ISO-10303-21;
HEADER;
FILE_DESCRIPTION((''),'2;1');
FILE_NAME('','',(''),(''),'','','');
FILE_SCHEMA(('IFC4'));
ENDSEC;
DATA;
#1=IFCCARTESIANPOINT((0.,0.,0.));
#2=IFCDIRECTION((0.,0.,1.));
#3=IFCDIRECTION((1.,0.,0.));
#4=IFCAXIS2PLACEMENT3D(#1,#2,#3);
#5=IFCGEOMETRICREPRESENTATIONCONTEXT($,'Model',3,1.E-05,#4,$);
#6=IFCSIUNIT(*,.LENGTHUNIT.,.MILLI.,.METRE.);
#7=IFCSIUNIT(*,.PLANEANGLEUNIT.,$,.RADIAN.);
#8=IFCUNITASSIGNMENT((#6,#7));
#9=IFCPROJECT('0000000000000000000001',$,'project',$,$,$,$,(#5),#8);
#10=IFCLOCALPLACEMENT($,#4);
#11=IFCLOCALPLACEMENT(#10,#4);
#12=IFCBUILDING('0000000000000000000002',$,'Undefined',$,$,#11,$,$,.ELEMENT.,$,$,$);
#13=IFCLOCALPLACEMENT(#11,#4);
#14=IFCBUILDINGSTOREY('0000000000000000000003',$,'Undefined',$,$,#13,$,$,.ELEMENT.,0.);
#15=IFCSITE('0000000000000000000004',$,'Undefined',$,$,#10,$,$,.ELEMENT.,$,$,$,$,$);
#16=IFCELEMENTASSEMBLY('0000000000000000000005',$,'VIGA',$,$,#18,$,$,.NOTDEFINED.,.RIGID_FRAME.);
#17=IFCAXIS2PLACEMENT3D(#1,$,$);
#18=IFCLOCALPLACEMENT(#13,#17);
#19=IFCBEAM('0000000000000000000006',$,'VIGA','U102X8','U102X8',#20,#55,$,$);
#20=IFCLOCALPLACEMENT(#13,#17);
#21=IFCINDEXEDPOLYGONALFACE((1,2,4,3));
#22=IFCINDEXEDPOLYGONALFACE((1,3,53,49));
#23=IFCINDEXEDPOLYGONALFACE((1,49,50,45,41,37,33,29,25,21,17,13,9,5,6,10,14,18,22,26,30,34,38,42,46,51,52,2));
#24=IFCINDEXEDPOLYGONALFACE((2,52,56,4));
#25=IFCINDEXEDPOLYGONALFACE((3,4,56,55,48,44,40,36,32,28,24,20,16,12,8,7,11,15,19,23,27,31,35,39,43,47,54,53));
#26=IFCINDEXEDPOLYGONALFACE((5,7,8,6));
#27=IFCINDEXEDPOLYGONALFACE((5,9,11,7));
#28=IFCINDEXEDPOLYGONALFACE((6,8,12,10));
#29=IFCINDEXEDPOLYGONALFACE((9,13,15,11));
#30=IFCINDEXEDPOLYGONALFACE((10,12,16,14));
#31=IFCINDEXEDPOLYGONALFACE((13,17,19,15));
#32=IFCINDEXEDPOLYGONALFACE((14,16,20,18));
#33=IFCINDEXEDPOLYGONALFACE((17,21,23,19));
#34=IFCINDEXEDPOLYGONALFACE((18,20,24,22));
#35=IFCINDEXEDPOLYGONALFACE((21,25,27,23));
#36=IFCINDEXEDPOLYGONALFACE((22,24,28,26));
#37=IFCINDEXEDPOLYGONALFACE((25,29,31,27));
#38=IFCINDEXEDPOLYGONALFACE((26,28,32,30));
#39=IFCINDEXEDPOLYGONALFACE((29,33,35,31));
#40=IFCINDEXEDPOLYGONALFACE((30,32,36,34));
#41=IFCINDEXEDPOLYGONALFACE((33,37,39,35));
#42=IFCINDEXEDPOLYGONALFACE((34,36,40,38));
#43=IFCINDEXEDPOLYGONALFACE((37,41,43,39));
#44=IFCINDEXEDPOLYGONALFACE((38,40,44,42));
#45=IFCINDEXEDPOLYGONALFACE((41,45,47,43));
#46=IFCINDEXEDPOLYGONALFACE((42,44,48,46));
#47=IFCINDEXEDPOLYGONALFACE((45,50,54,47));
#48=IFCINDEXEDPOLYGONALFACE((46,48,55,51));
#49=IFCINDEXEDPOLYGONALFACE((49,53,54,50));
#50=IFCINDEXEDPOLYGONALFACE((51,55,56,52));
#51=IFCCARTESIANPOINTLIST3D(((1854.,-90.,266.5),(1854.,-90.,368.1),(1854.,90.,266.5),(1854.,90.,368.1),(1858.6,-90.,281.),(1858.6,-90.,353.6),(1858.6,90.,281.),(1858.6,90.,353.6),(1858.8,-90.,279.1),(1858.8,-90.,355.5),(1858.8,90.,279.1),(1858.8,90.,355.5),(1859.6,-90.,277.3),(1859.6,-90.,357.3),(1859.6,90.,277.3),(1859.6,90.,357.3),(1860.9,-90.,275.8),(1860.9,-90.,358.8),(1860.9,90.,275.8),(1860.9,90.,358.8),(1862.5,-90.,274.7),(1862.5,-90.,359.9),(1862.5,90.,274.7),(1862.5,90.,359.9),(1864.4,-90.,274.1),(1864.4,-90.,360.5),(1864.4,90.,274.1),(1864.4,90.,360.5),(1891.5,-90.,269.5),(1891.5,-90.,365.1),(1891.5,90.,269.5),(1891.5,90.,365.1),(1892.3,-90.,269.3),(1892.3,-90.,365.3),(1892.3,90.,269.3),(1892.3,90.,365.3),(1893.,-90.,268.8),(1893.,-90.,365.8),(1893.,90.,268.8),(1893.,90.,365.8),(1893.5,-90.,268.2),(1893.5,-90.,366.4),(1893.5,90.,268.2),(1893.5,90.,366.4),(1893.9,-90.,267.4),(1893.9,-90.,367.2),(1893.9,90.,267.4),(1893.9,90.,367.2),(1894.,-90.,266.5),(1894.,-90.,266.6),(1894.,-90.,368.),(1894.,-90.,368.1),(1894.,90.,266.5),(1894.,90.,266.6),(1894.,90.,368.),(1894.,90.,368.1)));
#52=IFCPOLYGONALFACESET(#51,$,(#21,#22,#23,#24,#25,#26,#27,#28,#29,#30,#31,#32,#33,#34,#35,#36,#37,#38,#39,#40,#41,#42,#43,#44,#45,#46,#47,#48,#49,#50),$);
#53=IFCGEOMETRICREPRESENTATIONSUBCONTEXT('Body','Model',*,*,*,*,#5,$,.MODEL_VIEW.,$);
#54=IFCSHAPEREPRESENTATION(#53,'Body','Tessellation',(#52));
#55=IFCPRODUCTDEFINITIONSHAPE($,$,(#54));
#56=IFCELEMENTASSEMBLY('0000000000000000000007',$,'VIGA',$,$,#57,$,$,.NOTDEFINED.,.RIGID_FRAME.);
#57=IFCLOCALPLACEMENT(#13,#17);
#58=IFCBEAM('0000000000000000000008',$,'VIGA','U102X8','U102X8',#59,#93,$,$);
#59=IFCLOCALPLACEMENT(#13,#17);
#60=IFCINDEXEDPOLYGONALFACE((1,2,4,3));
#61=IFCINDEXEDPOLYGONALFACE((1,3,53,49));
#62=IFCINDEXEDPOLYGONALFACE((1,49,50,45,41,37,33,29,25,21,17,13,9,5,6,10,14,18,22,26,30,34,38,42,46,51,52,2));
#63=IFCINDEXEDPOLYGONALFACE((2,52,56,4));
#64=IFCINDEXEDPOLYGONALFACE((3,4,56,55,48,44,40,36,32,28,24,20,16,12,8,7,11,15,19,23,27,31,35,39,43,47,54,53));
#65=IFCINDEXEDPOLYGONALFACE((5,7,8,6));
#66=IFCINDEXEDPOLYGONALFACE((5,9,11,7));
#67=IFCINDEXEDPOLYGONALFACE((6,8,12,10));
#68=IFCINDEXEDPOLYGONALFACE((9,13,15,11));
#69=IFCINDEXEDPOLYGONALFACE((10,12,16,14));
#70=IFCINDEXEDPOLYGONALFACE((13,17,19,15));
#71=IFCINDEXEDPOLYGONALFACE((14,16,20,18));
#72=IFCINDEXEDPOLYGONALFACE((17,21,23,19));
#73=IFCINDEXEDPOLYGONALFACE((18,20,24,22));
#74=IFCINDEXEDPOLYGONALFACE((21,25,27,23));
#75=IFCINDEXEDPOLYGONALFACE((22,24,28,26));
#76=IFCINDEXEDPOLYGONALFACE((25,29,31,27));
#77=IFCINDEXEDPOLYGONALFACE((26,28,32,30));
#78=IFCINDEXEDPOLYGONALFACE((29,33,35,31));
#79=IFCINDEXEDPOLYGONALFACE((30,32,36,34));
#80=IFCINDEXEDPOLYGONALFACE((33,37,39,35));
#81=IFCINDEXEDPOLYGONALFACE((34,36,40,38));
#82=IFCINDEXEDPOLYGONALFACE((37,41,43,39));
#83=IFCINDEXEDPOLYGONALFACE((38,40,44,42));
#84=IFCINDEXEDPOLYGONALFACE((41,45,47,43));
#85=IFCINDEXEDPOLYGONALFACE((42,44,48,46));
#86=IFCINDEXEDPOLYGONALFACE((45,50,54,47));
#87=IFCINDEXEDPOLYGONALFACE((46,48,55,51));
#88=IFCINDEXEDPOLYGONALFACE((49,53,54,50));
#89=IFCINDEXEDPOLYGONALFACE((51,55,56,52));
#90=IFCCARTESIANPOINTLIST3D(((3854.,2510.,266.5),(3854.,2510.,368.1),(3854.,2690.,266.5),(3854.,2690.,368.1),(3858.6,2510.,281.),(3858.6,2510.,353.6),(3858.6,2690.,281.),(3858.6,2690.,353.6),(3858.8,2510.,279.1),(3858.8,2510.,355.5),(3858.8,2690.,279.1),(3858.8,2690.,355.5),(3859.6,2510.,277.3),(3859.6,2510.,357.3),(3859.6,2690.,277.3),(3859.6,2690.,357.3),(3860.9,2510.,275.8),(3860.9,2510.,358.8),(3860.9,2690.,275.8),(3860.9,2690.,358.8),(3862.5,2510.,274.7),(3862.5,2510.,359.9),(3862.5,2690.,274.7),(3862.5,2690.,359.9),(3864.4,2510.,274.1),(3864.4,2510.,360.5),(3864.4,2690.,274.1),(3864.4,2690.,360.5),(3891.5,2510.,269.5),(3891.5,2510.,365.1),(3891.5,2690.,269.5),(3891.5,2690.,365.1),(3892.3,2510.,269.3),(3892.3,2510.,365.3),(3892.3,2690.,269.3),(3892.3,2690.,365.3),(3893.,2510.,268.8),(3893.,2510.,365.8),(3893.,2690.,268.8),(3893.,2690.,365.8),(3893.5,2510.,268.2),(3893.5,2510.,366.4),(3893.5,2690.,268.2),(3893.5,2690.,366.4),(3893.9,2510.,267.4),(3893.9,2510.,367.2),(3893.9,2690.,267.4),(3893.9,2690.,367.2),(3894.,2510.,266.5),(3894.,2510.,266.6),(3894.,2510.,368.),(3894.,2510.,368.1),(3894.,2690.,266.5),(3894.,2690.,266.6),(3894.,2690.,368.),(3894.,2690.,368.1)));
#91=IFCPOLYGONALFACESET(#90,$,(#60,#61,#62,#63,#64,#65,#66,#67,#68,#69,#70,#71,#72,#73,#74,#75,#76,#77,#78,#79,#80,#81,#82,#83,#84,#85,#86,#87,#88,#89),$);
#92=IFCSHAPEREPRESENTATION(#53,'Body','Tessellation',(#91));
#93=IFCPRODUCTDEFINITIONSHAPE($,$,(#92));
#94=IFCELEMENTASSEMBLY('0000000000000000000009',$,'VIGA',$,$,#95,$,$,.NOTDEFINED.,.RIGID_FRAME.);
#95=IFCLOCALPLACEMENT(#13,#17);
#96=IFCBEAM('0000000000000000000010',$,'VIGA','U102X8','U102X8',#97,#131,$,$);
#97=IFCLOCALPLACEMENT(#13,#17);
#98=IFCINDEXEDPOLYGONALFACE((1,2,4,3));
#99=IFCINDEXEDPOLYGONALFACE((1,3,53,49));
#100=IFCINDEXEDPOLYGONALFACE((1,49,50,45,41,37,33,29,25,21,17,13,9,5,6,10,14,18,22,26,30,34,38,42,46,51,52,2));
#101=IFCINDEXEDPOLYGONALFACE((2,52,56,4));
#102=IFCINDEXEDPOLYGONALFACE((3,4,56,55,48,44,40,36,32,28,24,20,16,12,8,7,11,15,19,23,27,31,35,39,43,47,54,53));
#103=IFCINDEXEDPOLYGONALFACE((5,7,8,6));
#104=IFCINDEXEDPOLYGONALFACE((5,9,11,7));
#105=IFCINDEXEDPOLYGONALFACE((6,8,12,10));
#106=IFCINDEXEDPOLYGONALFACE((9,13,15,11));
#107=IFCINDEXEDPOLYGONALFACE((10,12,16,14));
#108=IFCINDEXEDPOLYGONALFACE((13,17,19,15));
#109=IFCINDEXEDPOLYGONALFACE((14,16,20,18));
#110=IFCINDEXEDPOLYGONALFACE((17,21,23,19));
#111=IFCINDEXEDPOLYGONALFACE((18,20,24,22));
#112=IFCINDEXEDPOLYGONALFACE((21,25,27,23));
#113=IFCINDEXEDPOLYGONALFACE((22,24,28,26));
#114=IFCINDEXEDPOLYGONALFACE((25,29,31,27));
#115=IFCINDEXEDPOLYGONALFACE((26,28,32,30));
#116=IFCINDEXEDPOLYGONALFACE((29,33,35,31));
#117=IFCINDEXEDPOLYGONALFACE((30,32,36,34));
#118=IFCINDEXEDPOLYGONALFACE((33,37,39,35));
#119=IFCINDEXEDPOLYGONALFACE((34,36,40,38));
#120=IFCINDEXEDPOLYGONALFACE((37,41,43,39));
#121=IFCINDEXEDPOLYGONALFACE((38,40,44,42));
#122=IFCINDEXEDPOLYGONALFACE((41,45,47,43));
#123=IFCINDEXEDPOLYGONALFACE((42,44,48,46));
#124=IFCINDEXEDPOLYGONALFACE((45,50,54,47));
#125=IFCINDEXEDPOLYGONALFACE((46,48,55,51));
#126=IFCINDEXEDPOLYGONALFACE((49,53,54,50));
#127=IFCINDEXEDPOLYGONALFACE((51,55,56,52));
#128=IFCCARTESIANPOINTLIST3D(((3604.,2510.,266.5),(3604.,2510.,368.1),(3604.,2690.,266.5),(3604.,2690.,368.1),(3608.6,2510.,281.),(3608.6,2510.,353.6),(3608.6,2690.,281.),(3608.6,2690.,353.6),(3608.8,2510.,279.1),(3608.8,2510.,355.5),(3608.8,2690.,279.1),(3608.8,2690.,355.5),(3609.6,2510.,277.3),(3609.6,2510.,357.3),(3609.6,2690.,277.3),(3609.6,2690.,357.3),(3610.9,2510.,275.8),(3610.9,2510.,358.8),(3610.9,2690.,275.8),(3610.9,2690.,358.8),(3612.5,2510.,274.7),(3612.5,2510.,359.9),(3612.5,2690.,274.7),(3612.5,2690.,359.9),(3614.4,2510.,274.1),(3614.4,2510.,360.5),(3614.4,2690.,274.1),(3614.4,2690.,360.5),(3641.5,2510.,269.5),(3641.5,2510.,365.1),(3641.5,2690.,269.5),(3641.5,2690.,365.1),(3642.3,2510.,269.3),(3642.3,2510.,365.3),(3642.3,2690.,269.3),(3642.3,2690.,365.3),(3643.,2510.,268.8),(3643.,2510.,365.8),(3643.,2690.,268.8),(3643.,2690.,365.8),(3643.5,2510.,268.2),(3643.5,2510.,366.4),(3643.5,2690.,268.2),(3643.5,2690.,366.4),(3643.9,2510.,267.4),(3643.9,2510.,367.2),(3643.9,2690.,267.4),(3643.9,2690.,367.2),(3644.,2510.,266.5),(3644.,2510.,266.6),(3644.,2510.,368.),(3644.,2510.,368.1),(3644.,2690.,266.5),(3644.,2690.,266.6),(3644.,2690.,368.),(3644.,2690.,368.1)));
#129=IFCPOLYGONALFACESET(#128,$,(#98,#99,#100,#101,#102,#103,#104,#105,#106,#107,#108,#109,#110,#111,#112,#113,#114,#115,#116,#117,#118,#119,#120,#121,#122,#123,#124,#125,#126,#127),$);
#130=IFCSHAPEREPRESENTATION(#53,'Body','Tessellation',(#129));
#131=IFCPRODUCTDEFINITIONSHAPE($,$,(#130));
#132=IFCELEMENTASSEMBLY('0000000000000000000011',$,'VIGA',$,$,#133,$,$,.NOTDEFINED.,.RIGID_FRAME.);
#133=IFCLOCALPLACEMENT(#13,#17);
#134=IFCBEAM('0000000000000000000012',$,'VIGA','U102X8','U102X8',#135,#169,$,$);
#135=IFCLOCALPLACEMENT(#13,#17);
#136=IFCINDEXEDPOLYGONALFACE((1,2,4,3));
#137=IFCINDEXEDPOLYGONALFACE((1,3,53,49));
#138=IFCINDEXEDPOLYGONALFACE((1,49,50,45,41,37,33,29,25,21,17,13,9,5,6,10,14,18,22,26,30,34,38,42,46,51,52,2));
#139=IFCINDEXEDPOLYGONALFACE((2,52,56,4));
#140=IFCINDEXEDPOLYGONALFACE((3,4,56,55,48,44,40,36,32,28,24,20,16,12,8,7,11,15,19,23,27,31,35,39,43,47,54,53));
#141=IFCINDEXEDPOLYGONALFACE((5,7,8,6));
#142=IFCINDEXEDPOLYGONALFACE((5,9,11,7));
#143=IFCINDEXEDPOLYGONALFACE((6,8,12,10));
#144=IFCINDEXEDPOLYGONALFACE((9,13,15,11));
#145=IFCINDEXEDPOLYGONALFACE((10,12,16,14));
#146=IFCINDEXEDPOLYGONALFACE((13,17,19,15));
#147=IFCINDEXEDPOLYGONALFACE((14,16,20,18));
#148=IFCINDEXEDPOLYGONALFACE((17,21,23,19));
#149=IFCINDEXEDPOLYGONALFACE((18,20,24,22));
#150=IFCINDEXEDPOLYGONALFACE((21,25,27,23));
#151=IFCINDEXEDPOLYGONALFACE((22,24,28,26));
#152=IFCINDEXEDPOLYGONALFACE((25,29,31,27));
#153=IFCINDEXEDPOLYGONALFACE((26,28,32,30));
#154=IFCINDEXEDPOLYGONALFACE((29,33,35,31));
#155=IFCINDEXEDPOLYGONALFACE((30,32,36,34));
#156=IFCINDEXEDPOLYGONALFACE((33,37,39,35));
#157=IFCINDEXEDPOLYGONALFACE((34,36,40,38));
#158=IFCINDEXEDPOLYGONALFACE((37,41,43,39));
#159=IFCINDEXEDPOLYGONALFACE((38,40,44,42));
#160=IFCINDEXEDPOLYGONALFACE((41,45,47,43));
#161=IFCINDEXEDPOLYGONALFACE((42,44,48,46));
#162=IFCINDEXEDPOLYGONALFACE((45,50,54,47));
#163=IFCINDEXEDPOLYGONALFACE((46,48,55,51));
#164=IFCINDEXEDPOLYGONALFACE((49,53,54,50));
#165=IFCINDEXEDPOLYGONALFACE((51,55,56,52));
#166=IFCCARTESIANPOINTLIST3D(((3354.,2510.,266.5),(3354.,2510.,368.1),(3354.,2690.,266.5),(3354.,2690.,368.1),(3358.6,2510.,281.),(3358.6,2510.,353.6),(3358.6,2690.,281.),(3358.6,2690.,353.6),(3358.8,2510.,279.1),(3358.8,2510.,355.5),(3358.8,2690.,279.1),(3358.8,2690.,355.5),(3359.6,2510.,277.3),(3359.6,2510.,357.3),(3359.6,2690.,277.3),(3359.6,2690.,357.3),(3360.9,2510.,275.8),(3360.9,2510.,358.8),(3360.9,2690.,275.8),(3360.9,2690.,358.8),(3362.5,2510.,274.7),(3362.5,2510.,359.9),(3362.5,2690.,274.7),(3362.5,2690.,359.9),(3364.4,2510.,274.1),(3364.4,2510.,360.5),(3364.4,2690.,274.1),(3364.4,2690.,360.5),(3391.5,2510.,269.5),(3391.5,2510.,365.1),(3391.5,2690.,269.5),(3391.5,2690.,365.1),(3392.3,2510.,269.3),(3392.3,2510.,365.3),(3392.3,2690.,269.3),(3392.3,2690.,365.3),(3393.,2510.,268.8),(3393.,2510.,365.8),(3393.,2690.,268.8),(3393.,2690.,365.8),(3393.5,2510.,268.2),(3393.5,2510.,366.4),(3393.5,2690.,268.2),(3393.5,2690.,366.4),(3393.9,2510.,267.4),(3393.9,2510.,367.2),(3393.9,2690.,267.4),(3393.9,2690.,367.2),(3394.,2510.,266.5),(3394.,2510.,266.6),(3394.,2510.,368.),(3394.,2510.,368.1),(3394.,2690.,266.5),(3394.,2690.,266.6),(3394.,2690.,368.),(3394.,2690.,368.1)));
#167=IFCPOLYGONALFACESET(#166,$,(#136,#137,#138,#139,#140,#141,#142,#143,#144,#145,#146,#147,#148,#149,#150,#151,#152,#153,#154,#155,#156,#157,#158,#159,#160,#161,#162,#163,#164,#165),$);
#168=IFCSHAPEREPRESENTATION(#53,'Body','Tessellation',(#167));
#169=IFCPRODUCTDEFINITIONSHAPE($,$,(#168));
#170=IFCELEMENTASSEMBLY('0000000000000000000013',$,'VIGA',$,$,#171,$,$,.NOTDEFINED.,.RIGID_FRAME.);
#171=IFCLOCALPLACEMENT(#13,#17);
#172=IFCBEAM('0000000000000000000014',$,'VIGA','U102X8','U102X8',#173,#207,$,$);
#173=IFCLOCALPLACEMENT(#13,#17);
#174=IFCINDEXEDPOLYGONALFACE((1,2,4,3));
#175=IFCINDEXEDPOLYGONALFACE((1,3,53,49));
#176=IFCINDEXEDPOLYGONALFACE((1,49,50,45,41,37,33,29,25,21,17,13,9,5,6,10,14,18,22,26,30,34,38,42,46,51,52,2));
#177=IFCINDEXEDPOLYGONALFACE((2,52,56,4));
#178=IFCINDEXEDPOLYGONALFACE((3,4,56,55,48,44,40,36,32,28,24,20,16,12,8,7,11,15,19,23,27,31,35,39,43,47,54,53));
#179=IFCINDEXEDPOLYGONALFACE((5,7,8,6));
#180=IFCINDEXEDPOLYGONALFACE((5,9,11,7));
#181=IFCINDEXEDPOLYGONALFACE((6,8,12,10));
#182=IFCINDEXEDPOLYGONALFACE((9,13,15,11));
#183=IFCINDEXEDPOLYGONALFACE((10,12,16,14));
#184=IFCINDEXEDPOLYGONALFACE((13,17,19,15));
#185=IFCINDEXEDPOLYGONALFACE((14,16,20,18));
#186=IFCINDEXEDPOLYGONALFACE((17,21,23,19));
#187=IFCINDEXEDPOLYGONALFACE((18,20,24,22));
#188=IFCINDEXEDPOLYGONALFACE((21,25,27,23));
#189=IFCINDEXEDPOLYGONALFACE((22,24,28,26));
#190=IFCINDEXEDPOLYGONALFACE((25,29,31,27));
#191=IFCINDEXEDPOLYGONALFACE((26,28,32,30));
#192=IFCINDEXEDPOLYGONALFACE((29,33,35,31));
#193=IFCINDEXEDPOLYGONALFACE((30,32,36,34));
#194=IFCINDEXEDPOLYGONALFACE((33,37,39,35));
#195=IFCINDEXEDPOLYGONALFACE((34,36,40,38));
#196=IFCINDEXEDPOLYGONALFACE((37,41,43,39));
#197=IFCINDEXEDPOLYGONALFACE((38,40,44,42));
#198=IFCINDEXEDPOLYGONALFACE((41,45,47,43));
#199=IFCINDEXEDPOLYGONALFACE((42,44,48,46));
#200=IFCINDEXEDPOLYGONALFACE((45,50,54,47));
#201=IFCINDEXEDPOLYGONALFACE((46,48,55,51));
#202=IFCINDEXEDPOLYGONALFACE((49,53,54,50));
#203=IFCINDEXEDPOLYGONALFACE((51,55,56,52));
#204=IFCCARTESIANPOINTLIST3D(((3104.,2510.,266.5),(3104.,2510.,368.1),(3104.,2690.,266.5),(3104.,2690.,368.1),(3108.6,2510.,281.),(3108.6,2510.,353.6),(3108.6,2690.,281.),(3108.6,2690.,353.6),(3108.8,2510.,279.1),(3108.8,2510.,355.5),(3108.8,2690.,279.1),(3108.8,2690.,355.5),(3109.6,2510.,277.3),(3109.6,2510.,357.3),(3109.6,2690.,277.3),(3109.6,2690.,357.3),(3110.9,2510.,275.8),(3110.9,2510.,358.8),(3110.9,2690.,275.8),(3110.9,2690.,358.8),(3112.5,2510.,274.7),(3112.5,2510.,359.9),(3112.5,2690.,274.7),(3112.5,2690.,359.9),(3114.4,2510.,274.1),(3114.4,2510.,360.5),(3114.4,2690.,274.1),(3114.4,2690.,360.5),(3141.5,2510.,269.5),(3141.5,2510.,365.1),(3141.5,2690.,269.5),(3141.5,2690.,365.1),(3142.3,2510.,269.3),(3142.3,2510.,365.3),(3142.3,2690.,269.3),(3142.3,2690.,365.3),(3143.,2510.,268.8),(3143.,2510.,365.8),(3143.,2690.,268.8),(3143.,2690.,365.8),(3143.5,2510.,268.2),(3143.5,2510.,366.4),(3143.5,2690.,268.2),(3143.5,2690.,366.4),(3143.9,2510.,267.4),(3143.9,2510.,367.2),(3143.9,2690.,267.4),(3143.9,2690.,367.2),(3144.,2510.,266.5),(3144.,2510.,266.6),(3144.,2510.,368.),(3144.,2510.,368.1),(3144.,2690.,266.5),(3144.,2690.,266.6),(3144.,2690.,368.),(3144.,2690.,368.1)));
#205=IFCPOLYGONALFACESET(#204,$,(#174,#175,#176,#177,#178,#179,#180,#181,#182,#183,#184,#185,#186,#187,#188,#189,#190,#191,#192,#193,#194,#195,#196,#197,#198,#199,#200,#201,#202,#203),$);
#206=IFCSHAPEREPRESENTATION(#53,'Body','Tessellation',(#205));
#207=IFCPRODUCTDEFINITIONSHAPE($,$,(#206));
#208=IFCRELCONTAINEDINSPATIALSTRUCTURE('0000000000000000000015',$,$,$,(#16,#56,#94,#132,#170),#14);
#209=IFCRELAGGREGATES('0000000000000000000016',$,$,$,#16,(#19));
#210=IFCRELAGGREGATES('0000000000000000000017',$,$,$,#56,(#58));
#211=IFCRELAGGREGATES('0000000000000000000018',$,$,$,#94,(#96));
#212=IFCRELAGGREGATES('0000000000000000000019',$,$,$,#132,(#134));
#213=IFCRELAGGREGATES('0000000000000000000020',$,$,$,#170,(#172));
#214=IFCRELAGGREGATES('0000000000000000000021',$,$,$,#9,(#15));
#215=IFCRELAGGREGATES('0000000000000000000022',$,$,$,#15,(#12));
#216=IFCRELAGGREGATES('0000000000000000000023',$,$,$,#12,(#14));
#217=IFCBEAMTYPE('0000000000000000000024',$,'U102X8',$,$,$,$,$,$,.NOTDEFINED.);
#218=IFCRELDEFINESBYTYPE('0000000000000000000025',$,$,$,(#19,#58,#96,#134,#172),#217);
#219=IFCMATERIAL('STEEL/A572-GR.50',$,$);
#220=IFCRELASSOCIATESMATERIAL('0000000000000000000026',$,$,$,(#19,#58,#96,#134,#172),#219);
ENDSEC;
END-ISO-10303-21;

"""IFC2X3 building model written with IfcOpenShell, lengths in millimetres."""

from ifc_helpers import new_model, si_unit, frame, origin_with_axes, origin_2d_with_axis, place, context, subcontext, project, spatial, u_section, extrude, material, type_object, element, aggregate, save


model = new_model("IFC2X3")

# Units and contexts
model_context = context("Model", 3, precision=1e-05, world=origin_with_axes())
body_context = subcontext(model_context, "Body", "Model", "MODEL_VIEW")
ifc_project = project(units=[si_unit("LENGTHUNIT", "METRE", prefix="MILLI"), si_unit("PLANEANGLEUNIT", "RADIAN")], contexts=[model_context])

# Site, building, storey
site_placement = place(None, origin_with_axes())
site = spatial("IfcSite", under=ifc_project, at=site_placement, Name="Undefined", CompositionType="ELEMENT")
building_placement = place(site_placement, origin_with_axes())
building = spatial("IfcBuilding", under=site, at=building_placement, Name="Undefined", CompositionType="ELEMENT")
storey_placement = place(building_placement, origin_with_axes())
storey = spatial("IfcBuildingStorey", under=building, at=storey_placement, Name="Undefined", CompositionType="ELEMENT", Elevation=0.0)

# Element assemblies, beams
ifc_material_1 = material(Name="STEEL/A572-GR.50")
beam_type_1 = type_object("IfcBeamType", Name="U102X8", PredefinedType="NOTDEFINED")
assembly_1_placement = place(storey_placement, origin_with_axes())
assembly_1 = element("IfcElementAssembly", 1, at=assembly_1_placement, inside=storey, Name="VIGA", AssemblyPlace="NOTDEFINED", PredefinedType="RIGID_FRAME")
beam_1_placement = place(assembly_1_placement, frame((1874.0, -90.0, 317.3), z_axis=(0.0, 0.0, 1.0), x_axis=(0.0, 1.0, 0.0)))
beam_1 = element("IfcBeam", 2, at=beam_1_placement, type_object=beam_type_1, material=ifc_material_1, Name="VIGA", Description="U102X8", ObjectType="U102X8", context=body_context, shape_type="SweptSolid", body=[
    extrude(u_section(Depth=101.6, FlangeWidth=40.0, WebThickness=4.6, FlangeThickness=6.0, FilletRadius=7.0, EdgeRadius=3.0, FlangeSlope=0.16839, at=origin_2d_with_axis()), frame((180.0, 0.0, 0.0), z_axis=(-1.0, 0.0, 0.0), x_axis=(0.0, -1.0, 0.0)), (0.0, 0.0, 1.0), 180.0),
])
aggregate(assembly_1, [beam_1])
assembly_2_placement = place(storey_placement, origin_with_axes())
assembly_2 = element("IfcElementAssembly", 3, at=assembly_2_placement, inside=storey, Name="VIGA", AssemblyPlace="NOTDEFINED", PredefinedType="RIGID_FRAME")
beam_2_placement = place(assembly_2_placement, frame((3874.0, 2510.0, 317.3), z_axis=(0.0, 0.0, 1.0), x_axis=(0.0, 1.0, 0.0)))
beam_2 = element("IfcBeam", 4, at=beam_2_placement, type_object=beam_type_1, material=ifc_material_1, Name="VIGA", Description="U102X8", ObjectType="U102X8", context=body_context, shape_type="SweptSolid", body=[
    extrude(u_section(Depth=101.6, FlangeWidth=40.0, WebThickness=4.6, FlangeThickness=6.0, FilletRadius=7.0, EdgeRadius=3.0, FlangeSlope=0.16839, at=origin_2d_with_axis()), frame((180.0, 0.0, 0.0), z_axis=(-1.0, 0.0, 0.0), x_axis=(0.0, -1.0, 0.0)), (0.0, 0.0, 1.0), 180.0),
])
aggregate(assembly_2, [beam_2])
assembly_3_placement = place(storey_placement, origin_with_axes())
assembly_3 = element("IfcElementAssembly", 5, at=assembly_3_placement, inside=storey, Name="VIGA", AssemblyPlace="NOTDEFINED", PredefinedType="RIGID_FRAME")
beam_3_placement = place(assembly_3_placement, frame((3624.0, 2510.0, 317.3), z_axis=(0.0, 0.0, 1.0), x_axis=(0.0, 1.0, 0.0)))
beam_3 = element("IfcBeam", 6, at=beam_3_placement, type_object=beam_type_1, material=ifc_material_1, Name="VIGA", Description="U102X8", ObjectType="U102X8", context=body_context, shape_type="SweptSolid", body=[
    extrude(u_section(Depth=101.6, FlangeWidth=40.0, WebThickness=4.6, FlangeThickness=6.0, FilletRadius=7.0, EdgeRadius=3.0, FlangeSlope=0.16839, at=origin_2d_with_axis()), frame((180.0, 0.0, 0.0), z_axis=(-1.0, 0.0, 0.0), x_axis=(0.0, -1.0, 0.0)), (0.0, 0.0, 1.0), 180.0),
])
aggregate(assembly_3, [beam_3])
assembly_4_placement = place(storey_placement, origin_with_axes())
assembly_4 = element("IfcElementAssembly", 7, at=assembly_4_placement, inside=storey, Name="VIGA", AssemblyPlace="NOTDEFINED", PredefinedType="RIGID_FRAME")
beam_4_placement = place(assembly_4_placement, frame((3374.0, 2510.0, 317.3), z_axis=(0.0, 0.0, 1.0), x_axis=(0.0, 1.0, 0.0)))
beam_4 = element("IfcBeam", 8, at=beam_4_placement, type_object=beam_type_1, material=ifc_material_1, Name="VIGA", Description="U102X8", ObjectType="U102X8", context=body_context, shape_type="SweptSolid", body=[
    extrude(u_section(Depth=101.6, FlangeWidth=40.0, WebThickness=4.6, FlangeThickness=6.0, FilletRadius=7.0, EdgeRadius=3.0, FlangeSlope=0.16839, at=origin_2d_with_axis()), frame((180.0, 0.0, 0.0), z_axis=(-1.0, 0.0, 0.0), x_axis=(0.0, -1.0, 0.0)), (0.0, 0.0, 1.0), 180.0),
])
aggregate(assembly_4, [beam_4])
assembly_5_placement = place(storey_placement, origin_with_axes())
assembly_5 = element("IfcElementAssembly", 9, at=assembly_5_placement, inside=storey, Name="VIGA", AssemblyPlace="NOTDEFINED", PredefinedType="RIGID_FRAME")
beam_5_placement = place(assembly_5_placement, frame((3124.0, 2510.0, 317.3), z_axis=(0.0, 0.0, 1.0), x_axis=(0.0, 1.0, 0.0)))
beam_5 = element("IfcBeam", 10, at=beam_5_placement, type_object=beam_type_1, material=ifc_material_1, Name="VIGA", Description="U102X8", ObjectType="U102X8", context=body_context, shape_type="SweptSolid", body=[
    extrude(u_section(Depth=101.6, FlangeWidth=40.0, WebThickness=4.6, FlangeThickness=6.0, FilletRadius=7.0, EdgeRadius=3.0, FlangeSlope=0.16839, at=origin_2d_with_axis()), frame((180.0, 0.0, 0.0), z_axis=(-1.0, 0.0, 0.0), x_axis=(0.0, -1.0, 0.0)), (0.0, 0.0, 1.0), 180.0),
])
aggregate(assembly_5, [beam_5])

save(model, "model.ifc")
